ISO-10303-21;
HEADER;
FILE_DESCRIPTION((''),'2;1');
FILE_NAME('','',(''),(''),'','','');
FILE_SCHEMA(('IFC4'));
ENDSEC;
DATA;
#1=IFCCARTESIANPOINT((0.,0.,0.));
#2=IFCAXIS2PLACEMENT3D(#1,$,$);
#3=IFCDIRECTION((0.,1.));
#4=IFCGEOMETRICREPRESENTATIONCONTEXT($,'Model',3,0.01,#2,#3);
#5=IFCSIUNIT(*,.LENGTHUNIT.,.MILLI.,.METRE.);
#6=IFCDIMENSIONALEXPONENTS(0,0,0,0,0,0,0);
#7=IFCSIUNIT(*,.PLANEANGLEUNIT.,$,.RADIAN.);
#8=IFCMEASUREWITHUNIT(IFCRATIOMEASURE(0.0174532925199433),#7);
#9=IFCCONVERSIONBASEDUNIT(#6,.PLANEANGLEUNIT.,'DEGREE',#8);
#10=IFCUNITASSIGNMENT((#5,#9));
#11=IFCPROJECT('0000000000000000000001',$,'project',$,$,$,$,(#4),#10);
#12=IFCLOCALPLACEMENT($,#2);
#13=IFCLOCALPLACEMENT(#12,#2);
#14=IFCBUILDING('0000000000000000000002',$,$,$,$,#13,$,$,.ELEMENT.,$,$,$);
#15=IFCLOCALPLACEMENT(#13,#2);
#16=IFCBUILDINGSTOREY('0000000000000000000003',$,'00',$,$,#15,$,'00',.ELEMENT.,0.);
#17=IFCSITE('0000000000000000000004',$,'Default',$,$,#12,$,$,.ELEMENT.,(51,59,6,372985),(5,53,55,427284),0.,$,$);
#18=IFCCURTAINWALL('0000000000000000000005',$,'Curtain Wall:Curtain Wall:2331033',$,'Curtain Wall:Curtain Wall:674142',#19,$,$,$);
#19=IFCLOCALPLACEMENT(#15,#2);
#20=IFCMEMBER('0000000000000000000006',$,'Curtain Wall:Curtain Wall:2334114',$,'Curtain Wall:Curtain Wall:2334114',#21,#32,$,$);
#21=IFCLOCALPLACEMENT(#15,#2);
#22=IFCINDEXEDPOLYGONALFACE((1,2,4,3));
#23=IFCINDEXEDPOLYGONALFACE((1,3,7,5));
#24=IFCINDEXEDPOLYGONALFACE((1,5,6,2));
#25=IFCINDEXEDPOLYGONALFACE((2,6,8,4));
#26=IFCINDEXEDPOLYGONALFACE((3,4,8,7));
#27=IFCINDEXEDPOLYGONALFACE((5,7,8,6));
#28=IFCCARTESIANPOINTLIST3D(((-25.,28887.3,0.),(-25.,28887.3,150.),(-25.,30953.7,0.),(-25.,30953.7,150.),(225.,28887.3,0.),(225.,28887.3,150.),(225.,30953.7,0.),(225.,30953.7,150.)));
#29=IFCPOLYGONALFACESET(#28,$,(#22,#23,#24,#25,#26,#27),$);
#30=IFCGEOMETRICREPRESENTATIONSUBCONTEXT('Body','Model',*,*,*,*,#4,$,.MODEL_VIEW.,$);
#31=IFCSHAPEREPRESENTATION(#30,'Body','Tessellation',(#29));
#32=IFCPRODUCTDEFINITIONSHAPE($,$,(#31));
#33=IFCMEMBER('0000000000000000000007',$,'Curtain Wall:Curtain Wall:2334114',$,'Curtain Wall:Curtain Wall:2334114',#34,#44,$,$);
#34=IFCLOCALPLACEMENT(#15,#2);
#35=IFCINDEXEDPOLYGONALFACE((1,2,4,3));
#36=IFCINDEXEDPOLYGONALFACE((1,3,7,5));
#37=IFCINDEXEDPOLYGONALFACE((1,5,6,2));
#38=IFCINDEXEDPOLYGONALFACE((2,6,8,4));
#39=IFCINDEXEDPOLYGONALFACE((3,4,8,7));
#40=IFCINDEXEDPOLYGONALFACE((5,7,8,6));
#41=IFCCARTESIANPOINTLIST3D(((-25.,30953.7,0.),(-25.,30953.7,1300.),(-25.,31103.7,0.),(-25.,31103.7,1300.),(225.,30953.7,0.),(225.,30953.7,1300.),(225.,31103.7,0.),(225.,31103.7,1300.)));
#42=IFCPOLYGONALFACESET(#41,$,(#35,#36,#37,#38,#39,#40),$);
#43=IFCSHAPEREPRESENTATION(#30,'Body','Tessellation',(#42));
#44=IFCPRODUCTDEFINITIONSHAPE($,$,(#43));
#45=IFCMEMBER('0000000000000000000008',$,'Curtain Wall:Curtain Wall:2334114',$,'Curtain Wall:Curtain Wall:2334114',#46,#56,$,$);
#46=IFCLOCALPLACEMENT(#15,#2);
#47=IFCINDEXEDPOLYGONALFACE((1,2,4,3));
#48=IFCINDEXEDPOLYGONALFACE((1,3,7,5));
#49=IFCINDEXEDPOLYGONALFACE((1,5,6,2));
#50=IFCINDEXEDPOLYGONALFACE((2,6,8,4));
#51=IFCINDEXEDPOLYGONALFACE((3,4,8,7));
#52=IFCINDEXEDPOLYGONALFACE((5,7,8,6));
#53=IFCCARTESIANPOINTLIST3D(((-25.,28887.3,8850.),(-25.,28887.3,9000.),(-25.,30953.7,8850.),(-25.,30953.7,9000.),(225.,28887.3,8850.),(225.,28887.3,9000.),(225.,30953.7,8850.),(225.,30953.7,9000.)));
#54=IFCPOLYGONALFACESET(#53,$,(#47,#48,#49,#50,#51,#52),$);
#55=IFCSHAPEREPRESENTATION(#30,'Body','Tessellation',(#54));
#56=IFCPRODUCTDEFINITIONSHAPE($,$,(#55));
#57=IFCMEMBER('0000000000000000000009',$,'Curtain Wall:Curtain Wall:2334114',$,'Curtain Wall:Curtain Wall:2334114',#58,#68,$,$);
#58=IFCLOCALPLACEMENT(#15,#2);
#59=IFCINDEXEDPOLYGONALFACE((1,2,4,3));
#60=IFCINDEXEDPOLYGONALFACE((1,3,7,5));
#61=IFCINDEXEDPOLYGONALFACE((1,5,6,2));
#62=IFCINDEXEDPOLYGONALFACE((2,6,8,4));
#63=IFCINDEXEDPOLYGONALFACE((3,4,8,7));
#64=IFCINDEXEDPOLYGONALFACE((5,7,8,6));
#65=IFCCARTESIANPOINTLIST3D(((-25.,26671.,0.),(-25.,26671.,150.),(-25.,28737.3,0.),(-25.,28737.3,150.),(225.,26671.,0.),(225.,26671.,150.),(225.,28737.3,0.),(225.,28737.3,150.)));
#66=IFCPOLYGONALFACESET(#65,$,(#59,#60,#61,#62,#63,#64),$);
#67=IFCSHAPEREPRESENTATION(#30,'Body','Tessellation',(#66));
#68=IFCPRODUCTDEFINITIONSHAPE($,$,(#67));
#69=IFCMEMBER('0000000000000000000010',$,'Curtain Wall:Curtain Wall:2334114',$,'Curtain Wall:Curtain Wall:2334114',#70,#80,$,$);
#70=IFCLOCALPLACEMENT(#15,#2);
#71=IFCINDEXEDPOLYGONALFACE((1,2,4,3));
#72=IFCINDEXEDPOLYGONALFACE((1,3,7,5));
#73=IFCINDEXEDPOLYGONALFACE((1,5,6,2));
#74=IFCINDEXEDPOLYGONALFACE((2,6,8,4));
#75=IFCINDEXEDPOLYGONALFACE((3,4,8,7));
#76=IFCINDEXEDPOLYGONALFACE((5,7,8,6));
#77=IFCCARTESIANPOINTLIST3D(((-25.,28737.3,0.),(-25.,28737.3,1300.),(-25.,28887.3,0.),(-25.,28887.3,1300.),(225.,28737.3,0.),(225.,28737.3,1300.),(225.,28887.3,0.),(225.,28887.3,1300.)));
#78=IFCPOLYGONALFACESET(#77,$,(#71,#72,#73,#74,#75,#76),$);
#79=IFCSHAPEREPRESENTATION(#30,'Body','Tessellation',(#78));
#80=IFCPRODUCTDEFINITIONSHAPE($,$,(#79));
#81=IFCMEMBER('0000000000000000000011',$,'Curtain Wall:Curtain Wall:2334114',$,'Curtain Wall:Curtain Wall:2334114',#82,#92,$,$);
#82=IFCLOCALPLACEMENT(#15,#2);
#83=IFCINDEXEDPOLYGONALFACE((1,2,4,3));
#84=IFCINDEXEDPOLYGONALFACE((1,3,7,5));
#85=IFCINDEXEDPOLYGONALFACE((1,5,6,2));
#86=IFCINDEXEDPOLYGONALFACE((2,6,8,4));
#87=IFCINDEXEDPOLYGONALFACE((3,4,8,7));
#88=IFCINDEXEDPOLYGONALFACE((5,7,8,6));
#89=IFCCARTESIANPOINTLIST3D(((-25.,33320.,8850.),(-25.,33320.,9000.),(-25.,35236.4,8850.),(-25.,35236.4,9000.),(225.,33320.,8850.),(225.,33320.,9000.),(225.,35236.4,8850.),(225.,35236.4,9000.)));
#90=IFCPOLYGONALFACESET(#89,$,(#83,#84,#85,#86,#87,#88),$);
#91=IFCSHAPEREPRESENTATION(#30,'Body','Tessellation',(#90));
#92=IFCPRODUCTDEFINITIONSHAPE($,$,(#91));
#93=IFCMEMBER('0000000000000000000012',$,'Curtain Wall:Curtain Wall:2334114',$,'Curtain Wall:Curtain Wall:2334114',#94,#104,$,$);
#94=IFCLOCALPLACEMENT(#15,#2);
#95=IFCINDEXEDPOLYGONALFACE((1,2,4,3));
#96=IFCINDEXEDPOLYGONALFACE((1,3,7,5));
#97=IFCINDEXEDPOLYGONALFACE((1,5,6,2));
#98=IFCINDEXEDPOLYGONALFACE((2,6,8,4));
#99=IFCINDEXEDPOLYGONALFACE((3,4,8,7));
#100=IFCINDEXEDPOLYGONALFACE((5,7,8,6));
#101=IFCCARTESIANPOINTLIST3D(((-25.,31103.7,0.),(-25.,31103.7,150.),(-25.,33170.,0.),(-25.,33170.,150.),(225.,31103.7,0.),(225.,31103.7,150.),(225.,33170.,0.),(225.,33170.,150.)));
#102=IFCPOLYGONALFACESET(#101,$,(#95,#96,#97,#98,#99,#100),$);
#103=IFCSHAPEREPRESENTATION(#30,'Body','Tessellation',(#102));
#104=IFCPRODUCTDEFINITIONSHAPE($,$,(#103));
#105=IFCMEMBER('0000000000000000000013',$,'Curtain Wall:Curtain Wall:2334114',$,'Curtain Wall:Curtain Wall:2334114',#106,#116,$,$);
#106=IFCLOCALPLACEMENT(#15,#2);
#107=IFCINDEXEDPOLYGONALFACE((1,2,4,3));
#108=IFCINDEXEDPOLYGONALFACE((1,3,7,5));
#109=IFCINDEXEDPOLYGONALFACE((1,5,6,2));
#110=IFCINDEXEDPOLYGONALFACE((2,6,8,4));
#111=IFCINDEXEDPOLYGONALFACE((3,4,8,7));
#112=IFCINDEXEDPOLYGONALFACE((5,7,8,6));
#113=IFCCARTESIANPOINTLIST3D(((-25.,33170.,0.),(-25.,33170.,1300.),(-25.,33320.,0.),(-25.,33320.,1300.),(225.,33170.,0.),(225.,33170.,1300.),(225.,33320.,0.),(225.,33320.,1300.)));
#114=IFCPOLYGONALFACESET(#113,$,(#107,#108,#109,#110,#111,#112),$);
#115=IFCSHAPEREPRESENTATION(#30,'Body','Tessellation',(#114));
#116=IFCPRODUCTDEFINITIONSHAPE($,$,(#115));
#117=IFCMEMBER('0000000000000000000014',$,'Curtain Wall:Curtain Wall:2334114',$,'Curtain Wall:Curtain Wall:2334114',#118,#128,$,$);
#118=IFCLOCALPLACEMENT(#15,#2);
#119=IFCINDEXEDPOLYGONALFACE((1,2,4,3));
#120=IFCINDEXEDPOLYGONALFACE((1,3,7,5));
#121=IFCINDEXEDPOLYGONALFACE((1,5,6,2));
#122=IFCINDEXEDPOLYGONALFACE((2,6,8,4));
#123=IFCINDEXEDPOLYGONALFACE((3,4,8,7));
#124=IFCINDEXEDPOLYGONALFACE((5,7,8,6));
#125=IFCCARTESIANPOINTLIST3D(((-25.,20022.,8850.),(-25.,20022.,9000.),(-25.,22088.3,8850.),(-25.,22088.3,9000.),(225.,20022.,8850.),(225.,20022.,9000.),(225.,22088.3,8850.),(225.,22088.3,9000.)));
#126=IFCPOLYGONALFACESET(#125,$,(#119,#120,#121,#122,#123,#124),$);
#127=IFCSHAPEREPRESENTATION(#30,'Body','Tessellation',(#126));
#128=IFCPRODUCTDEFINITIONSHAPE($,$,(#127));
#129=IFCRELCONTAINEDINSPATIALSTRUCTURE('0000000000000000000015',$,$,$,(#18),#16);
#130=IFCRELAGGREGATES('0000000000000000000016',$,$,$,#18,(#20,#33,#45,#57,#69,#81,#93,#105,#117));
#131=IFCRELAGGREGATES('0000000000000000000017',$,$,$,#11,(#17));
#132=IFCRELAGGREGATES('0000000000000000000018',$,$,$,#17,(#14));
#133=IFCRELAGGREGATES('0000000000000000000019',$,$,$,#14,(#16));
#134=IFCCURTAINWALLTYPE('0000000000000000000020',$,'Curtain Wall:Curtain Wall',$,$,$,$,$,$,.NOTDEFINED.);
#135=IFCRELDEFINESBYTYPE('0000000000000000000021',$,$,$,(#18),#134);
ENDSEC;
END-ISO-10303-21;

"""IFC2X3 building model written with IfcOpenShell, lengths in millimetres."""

from ifc_helpers import new_model, entity, si_unit, converted_unit, direction, frame, frame_2d, origin, origin_2d_with_axis, place, context, subcontext, project, spatial, rectangle, extrude, type_object, element, aggregate, save


model = new_model("IFC2X3")

# Units and contexts
model_context = context("Model", 3, precision=0.01, world=origin(), true_north=direction((0.0, 1.0)))
body_context = subcontext(model_context, "Body", "Model", "MODEL_VIEW")
ifc_project = project(units=[si_unit("LENGTHUNIT", "METRE", prefix="MILLI"), converted_unit("PLANEANGLEUNIT", "DEGREE", entity("IfcRatioMeasure", 0.0174532925199433), si_unit("PLANEANGLEUNIT", "RADIAN"), dimensions=[0, 0, 0, 0, 0, 0, 0])], contexts=[model_context])

# Site, building, storey
site_placement = place(None, origin())
site = spatial("IfcSite", under=ifc_project, at=site_placement, Name="Default", CompositionType="ELEMENT", RefLatitude=(51, 59, 6, 372985), RefLongitude=(5, 53, 55, 427284), RefElevation=0.0)
building_placement = place(site_placement, origin())
building = spatial("IfcBuilding", under=site, at=building_placement, CompositionType="ELEMENT")
storey_placement = place(building_placement, origin())
storey = spatial("IfcBuildingStorey", under=building, at=storey_placement, Name="00", LongName="00", CompositionType="ELEMENT", Elevation=0.0)

# Curtain wall, members
curtain_wall_type = type_object("IfcCurtainWallType", Name="Curtain Wall:Curtain Wall", PredefinedType="NOTDEFINED")
curtain_wall_placement = place(storey_placement, origin())
curtain_wall = element("IfcCurtainWall", 1, at=curtain_wall_placement, inside=storey, type_object=curtain_wall_type, Name="Curtain Wall:Curtain Wall:2331033", ObjectType="Curtain Wall:Curtain Wall:674142")
member_1_placement = place(curtain_wall_placement, origin())
member_1 = element("IfcMember", 2, at=member_1_placement, Name="Curtain Wall:Curtain Wall:2334114", ObjectType="Curtain Wall:Curtain Wall:2334114", context=body_context, shape_type="SweptSolid", body=[
    extrude(rectangle(XDim=150.0, YDim=250.0, at=origin_2d_with_axis()), frame((100.0, 30953.7, 75.0), z_axis=(0.0, -1.0, 0.0), x_axis=(0.0, 0.0, -1.0)), (0.0, 0.0, 1.0), 2066.3),
])
member_2_placement = place(curtain_wall_placement, origin())
member_2 = element("IfcMember", 3, at=member_2_placement, Name="Curtain Wall:Curtain Wall:2334114", ObjectType="Curtain Wall:Curtain Wall:2334114", context=body_context, shape_type="SweptSolid", body=[
    extrude(rectangle(XDim=250.0, YDim=150.0, at=frame_2d((0.0, 0.0), x_axis=(1.0, 0.0))), frame((100.0, 31028.7, 0.0), z_axis=(0.0, 0.0, 1.0), x_axis=(-1.0, 0.0, 0.0)), (0.0, 0.0, 1.0), 1300.0),
])
member_3_placement = place(curtain_wall_placement, origin())
member_3 = element("IfcMember", 4, at=member_3_placement, Name="Curtain Wall:Curtain Wall:2334114", ObjectType="Curtain Wall:Curtain Wall:2334114", context=body_context, shape_type="SweptSolid", body=[
    extrude(rectangle(XDim=150.0, YDim=250.0, at=origin_2d_with_axis()), frame((100.0, 28887.3, 8925.0), z_axis=(0.0, 1.0, 0.0), x_axis=(0.0, 0.0, -1.0)), (0.0, 0.0, 1.0), 2066.3),
])
member_4_placement = place(curtain_wall_placement, origin())
member_4 = element("IfcMember", 5, at=member_4_placement, Name="Curtain Wall:Curtain Wall:2334114", ObjectType="Curtain Wall:Curtain Wall:2334114", context=body_context, shape_type="SweptSolid", body=[
    extrude(rectangle(XDim=150.0, YDim=250.0, at=origin_2d_with_axis()), frame((100.0, 28737.3, 75.0), z_axis=(0.0, -1.0, 0.0), x_axis=(0.0, 0.0, -1.0)), (0.0, 0.0, 1.0), 2066.3),
])
member_5_placement = place(curtain_wall_placement, origin())
member_5 = element("IfcMember", 6, at=member_5_placement, Name="Curtain Wall:Curtain Wall:2334114", ObjectType="Curtain Wall:Curtain Wall:2334114", context=body_context, shape_type="SweptSolid", body=[
    extrude(rectangle(XDim=250.0, YDim=150.0, at=frame_2d((0.0, 0.0), x_axis=(1.0, 0.0))), frame((100.0, 28812.3, 0.0), z_axis=(0.0, 0.0, 1.0), x_axis=(-1.0, 0.0, 0.0)), (0.0, 0.0, 1.0), 1300.0),
])
member_6_placement = place(curtain_wall_placement, origin())
member_6 = element("IfcMember", 7, at=member_6_placement, Name="Curtain Wall:Curtain Wall:2334114", ObjectType="Curtain Wall:Curtain Wall:2334114", context=body_context, shape_type="SweptSolid", body=[
    extrude(rectangle(XDim=150.0, YDim=250.0, at=origin_2d_with_axis()), frame((100.0, 33320.0, 8925.0), z_axis=(0.0, 1.0, 0.0), x_axis=(0.0, 0.0, -1.0)), (0.0, 0.0, 1.0), 1916.3),
])
member_7_placement = place(curtain_wall_placement, origin())
member_7 = element("IfcMember", 8, at=member_7_placement, Name="Curtain Wall:Curtain Wall:2334114", ObjectType="Curtain Wall:Curtain Wall:2334114", context=body_context, shape_type="SweptSolid", body=[
    extrude(rectangle(XDim=150.0, YDim=250.0, at=origin_2d_with_axis()), frame((100.0, 33170.0, 75.0), z_axis=(0.0, -1.0, 0.0), x_axis=(0.0, 0.0, -1.0)), (0.0, 0.0, 1.0), 2066.3),
])
member_8_placement = place(curtain_wall_placement, origin())
member_8 = element("IfcMember", 9, at=member_8_placement, Name="Curtain Wall:Curtain Wall:2334114", ObjectType="Curtain Wall:Curtain Wall:2334114", context=body_context, shape_type="SweptSolid", body=[
    extrude(rectangle(XDim=250.0, YDim=150.0, at=origin_2d_with_axis()), frame((100.0, 33245.0, 0.0), z_axis=(0.0, 0.0, 1.0), x_axis=(-1.0, 0.0, 0.0)), (0.0, 0.0, 1.0), 1300.0),
])
member_9_placement = place(curtain_wall_placement, origin())
member_9 = element("IfcMember", 10, at=member_9_placement, Name="Curtain Wall:Curtain Wall:2334114", ObjectType="Curtain Wall:Curtain Wall:2334114", context=body_context, shape_type="SweptSolid", body=[
    extrude(rectangle(XDim=150.0, YDim=250.0, at=origin_2d_with_axis()), frame((100.0, 20022.0, 8925.0), z_axis=(0.0, 1.0, 0.0), x_axis=(0.0, 0.0, -1.0)), (0.0, 0.0, 1.0), 2066.3),
])
aggregate(curtain_wall, [member_1, member_2, member_3, member_4, member_5, member_6, member_7, member_8, member_9])

save(model, "model.ifc")
